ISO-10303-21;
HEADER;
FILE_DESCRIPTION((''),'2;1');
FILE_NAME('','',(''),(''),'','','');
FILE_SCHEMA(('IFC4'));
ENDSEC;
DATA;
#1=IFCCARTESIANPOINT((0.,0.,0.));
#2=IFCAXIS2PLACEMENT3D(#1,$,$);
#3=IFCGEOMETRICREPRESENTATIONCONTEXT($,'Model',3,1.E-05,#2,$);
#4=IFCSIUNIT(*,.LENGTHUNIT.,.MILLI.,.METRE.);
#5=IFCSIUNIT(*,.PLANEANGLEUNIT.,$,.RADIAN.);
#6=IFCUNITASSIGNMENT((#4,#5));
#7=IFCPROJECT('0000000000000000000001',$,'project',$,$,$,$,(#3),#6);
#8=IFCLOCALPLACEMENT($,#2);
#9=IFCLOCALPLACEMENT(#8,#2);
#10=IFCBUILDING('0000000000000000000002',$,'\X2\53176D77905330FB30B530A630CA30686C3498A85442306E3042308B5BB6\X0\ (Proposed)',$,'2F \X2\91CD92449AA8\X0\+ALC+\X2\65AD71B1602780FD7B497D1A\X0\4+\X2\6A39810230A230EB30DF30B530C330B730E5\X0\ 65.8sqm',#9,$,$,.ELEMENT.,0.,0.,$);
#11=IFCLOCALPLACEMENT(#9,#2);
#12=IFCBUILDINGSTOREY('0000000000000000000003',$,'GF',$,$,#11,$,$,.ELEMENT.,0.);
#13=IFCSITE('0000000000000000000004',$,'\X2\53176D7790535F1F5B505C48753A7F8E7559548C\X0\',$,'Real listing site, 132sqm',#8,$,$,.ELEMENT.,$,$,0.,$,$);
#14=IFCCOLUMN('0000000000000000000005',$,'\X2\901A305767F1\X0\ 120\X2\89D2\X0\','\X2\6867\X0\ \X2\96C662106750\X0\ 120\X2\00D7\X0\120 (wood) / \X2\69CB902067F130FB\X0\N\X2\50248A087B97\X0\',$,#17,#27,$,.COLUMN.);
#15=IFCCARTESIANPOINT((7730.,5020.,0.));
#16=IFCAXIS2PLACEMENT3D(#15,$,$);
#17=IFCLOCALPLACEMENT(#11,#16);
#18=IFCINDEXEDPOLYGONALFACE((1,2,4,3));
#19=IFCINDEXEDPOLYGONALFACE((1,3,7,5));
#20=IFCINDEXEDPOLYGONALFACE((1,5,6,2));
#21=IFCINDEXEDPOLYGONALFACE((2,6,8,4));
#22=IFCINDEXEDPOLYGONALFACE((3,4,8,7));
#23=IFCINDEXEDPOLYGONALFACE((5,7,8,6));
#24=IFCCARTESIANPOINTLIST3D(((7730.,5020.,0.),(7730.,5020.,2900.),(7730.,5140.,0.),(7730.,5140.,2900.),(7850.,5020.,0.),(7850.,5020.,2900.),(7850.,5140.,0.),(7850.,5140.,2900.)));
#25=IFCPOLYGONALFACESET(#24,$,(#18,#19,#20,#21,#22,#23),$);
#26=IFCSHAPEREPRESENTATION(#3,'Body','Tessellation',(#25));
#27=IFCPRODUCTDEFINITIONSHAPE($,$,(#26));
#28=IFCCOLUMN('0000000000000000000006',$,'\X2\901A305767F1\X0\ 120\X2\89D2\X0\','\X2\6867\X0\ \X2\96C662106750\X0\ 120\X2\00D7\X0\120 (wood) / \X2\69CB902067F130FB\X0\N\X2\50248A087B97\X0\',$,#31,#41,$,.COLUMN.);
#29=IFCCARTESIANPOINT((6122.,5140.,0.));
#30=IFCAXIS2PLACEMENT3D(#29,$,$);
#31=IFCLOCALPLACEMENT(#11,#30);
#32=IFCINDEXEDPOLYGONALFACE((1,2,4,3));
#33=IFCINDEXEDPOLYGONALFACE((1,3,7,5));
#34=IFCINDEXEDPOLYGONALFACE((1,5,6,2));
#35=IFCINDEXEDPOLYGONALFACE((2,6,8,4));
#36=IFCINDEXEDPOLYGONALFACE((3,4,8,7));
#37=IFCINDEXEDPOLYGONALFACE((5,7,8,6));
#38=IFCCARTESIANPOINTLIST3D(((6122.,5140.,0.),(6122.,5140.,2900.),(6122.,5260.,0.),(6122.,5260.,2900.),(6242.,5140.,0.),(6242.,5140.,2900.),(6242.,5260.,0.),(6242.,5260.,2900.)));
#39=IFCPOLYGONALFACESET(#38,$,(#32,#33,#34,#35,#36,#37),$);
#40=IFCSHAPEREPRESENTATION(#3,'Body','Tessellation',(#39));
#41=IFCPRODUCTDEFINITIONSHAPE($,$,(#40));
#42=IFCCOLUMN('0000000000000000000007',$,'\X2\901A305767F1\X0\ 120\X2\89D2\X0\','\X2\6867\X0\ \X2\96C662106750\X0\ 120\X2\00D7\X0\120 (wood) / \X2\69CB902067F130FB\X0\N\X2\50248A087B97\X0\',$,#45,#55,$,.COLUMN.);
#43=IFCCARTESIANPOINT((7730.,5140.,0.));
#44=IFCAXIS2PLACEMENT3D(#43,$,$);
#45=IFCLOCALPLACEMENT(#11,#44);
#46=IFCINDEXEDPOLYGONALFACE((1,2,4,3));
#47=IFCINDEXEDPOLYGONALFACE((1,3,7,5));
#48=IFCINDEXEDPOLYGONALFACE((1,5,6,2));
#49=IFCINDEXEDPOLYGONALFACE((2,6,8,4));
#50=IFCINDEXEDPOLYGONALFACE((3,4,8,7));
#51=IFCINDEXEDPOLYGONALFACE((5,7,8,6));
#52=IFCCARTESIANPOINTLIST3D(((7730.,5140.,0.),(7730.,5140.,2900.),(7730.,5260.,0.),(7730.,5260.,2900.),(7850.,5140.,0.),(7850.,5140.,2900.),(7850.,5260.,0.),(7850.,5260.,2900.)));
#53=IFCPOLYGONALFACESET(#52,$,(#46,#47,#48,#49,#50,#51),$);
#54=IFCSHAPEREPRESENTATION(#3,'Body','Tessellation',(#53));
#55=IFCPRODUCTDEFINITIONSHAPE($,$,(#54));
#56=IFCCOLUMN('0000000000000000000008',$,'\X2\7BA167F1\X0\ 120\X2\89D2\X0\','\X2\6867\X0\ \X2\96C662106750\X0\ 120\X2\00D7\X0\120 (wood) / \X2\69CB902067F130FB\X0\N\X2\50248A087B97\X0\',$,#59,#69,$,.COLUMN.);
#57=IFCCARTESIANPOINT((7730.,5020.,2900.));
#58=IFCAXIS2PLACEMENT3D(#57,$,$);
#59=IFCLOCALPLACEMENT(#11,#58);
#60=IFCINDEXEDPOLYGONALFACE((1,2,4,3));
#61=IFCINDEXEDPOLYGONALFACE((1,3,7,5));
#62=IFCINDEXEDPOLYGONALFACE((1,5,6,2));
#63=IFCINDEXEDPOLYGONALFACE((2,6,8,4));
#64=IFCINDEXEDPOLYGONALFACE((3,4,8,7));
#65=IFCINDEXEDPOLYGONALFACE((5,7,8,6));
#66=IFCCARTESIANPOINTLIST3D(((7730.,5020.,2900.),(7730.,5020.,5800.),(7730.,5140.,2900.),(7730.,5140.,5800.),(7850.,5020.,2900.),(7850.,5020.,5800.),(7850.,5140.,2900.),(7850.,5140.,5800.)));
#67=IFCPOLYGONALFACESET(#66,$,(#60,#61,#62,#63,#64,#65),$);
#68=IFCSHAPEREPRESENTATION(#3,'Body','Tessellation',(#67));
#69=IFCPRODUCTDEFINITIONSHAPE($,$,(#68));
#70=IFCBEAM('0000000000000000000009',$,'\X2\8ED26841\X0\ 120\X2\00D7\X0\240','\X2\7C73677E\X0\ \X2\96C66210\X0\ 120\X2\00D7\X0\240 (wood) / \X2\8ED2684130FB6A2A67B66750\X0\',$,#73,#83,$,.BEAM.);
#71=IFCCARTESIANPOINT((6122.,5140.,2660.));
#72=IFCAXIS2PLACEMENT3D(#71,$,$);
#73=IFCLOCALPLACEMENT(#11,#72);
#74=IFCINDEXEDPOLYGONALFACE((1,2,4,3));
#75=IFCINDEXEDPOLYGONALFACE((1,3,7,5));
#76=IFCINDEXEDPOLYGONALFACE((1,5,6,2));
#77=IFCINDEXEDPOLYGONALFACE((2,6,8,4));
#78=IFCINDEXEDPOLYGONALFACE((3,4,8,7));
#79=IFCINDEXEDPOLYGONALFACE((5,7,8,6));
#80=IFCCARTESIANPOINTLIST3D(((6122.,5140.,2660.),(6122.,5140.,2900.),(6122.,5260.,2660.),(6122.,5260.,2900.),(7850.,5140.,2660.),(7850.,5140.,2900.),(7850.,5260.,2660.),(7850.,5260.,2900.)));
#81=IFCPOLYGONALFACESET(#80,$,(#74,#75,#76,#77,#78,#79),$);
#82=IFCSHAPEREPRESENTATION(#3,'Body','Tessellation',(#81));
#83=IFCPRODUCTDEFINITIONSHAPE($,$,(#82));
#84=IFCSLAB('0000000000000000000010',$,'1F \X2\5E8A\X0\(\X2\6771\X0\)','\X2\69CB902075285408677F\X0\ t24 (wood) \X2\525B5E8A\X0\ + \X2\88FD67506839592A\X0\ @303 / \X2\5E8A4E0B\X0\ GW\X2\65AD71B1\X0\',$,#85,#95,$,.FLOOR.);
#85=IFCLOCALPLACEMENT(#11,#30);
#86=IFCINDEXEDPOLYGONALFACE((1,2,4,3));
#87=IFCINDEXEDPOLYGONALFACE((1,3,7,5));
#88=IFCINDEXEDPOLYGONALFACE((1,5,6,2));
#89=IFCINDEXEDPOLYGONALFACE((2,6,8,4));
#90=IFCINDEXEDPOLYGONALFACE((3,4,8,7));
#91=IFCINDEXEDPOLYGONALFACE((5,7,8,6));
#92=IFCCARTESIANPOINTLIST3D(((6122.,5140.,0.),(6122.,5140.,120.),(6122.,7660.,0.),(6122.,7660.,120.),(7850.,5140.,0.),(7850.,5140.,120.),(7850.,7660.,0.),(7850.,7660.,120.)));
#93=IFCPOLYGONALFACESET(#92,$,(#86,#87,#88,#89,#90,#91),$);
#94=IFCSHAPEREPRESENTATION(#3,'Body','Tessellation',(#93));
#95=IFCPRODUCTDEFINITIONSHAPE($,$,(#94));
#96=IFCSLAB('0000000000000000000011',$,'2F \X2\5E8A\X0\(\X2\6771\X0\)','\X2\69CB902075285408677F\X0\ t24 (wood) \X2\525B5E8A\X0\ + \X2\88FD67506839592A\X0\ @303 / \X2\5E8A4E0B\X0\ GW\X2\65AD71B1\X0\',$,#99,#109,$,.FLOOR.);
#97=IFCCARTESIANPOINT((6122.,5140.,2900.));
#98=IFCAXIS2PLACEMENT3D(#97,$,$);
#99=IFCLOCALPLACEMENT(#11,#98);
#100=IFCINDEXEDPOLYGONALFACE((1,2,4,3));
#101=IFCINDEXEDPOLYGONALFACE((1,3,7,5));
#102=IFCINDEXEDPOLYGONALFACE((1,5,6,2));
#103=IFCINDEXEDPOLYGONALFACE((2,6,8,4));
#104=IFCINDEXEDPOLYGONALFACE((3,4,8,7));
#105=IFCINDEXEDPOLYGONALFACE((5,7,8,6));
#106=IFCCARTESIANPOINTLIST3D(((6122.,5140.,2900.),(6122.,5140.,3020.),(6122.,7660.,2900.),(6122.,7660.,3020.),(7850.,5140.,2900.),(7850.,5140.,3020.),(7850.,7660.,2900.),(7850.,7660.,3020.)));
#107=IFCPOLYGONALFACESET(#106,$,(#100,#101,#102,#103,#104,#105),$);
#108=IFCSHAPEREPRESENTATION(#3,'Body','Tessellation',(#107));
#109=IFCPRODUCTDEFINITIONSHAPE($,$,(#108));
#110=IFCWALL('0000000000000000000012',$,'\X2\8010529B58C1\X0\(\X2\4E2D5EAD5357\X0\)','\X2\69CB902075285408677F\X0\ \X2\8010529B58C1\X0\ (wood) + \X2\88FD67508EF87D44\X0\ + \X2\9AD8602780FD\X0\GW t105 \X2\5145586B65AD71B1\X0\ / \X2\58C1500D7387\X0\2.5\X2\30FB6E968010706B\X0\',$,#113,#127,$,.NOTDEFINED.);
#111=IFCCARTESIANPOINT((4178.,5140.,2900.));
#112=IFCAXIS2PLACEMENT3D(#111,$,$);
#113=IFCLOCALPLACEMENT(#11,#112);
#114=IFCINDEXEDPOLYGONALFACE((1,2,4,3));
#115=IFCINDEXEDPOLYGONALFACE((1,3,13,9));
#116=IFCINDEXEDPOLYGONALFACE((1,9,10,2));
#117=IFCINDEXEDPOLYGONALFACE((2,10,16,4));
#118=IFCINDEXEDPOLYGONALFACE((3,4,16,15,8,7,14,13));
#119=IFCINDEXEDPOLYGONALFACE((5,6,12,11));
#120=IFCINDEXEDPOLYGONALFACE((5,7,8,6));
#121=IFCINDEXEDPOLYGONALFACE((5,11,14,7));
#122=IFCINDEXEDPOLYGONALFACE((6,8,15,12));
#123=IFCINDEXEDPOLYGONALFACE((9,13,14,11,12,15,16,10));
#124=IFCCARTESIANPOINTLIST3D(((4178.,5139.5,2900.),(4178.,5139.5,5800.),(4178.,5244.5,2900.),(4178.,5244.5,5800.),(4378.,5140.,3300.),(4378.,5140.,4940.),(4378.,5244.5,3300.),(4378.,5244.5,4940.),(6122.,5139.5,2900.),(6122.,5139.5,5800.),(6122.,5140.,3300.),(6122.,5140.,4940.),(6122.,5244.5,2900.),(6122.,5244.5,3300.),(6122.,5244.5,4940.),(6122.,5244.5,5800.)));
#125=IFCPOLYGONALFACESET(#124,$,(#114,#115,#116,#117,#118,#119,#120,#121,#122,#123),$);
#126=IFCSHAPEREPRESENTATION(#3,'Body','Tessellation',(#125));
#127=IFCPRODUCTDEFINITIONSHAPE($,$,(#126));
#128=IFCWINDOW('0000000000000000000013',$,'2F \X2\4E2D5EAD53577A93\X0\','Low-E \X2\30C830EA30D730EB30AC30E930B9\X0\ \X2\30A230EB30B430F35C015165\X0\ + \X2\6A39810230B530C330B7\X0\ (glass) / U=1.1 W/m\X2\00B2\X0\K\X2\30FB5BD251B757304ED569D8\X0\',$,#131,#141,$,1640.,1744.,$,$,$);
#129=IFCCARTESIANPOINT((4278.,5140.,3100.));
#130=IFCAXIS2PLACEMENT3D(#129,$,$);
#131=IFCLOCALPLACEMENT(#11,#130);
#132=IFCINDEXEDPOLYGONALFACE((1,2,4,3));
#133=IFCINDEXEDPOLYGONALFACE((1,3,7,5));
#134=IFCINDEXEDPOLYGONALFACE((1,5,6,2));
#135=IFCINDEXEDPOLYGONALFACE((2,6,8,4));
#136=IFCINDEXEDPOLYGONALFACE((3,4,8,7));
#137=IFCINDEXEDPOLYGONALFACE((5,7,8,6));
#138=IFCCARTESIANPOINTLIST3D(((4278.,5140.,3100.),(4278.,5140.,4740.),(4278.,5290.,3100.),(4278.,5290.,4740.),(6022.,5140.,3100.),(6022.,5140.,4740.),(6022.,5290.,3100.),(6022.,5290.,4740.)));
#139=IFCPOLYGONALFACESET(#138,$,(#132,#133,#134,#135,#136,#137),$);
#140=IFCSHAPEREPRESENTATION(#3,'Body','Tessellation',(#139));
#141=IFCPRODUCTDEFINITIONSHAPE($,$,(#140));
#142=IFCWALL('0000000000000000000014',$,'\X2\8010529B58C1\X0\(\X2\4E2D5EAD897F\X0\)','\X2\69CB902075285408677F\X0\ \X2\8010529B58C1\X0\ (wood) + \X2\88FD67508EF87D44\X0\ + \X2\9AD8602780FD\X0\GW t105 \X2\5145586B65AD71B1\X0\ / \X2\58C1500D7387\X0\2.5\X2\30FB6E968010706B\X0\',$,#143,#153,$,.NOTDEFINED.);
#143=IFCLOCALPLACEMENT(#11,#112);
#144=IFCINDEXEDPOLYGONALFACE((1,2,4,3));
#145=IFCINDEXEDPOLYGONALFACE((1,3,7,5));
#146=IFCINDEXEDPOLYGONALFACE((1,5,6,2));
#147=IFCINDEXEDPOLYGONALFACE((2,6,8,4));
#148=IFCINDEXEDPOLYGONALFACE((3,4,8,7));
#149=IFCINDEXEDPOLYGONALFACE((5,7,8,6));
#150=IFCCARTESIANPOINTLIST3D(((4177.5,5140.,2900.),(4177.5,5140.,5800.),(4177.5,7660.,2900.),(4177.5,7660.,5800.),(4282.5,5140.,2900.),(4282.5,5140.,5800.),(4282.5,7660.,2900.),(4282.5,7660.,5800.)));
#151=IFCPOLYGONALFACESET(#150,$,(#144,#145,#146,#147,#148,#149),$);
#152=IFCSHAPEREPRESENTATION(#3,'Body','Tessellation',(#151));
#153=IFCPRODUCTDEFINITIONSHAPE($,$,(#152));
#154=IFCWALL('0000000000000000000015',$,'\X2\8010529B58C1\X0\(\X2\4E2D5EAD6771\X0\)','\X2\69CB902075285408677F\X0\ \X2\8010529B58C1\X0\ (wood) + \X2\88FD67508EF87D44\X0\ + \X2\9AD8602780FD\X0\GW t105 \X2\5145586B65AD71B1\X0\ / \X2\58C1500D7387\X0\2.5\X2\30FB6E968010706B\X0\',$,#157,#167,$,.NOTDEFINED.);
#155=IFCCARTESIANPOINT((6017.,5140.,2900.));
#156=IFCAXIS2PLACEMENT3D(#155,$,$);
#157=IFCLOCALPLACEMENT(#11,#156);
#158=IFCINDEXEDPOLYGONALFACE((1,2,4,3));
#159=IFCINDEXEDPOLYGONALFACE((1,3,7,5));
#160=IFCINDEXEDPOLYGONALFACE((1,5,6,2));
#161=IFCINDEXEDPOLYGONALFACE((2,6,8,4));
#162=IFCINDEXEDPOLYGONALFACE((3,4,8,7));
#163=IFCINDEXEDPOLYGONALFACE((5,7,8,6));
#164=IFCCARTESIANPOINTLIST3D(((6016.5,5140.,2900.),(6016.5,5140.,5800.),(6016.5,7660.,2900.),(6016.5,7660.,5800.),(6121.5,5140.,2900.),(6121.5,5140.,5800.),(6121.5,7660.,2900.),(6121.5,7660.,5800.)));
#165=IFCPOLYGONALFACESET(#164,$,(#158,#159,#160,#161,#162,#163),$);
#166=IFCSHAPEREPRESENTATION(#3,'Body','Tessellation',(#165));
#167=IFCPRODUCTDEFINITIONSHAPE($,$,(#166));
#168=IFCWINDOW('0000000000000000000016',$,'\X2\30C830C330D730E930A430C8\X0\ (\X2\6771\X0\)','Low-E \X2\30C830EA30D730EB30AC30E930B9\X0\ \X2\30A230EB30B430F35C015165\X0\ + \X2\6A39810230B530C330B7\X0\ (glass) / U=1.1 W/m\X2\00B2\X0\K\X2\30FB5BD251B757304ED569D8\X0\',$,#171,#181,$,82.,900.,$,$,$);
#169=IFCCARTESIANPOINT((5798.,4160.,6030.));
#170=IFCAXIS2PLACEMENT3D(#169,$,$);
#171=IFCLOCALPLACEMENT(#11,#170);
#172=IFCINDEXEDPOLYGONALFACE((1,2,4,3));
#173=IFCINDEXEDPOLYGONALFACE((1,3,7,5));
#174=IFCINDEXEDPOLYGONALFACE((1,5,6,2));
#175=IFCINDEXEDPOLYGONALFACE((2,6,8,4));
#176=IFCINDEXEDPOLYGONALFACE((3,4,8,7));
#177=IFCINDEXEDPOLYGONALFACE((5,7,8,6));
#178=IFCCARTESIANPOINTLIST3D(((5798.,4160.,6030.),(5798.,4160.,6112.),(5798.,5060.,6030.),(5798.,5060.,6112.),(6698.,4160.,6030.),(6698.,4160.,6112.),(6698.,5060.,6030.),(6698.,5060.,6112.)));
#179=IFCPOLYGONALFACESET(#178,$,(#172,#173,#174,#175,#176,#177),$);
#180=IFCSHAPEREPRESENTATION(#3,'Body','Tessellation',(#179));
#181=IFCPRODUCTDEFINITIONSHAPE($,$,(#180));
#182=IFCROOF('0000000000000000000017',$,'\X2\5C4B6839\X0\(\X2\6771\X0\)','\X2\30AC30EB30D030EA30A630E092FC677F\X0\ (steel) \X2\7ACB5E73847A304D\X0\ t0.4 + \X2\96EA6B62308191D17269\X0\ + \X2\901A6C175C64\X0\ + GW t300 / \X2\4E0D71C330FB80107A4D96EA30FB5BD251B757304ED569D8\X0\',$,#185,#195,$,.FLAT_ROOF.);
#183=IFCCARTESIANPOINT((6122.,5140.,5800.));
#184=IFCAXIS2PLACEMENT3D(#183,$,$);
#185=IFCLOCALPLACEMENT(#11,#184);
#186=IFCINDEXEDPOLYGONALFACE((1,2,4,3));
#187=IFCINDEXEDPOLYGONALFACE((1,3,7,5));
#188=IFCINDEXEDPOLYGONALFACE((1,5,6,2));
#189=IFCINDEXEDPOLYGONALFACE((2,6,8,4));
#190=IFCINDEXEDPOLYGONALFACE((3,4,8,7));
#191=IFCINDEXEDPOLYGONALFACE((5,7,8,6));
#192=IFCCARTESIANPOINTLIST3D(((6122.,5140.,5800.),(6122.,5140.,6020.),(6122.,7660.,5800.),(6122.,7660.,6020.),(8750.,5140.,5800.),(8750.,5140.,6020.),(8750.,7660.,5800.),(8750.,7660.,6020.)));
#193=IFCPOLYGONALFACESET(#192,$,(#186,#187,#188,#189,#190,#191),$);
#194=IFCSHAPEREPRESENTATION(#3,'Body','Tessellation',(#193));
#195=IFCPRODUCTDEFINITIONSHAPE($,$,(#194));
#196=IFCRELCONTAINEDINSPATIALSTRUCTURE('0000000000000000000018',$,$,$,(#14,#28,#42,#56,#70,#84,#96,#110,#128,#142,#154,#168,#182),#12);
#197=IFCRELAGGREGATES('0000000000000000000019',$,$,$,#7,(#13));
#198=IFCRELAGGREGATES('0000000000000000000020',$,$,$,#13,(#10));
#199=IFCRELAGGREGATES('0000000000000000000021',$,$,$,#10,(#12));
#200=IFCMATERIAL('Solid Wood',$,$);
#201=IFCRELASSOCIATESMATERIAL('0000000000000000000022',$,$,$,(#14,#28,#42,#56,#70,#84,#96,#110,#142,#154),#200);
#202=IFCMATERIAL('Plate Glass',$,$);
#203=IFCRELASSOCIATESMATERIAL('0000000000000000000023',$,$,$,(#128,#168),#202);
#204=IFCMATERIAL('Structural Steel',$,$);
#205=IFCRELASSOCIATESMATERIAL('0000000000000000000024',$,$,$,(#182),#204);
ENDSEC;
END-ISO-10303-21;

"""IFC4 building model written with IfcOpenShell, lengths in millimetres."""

from ifc_helpers import new_model, si_unit, frame, frame_2d, origin, place, context, project, spatial, rectangle, extrude, material, element, fill, save


model = new_model("IFC4")

# Units and contexts
model_context = context("Model", 3, precision=1e-05, world=origin())
ifc_project = project(units=[si_unit("LENGTHUNIT", "METRE", prefix="MILLI"), si_unit("PLANEANGLEUNIT", "RADIAN")], contexts=[model_context])

# Site, building, storey
site_placement = place(None, origin())
site = spatial("IfcSite", under=ifc_project, at=site_placement, Name="北海道弟子屈町美留和", ObjectType="Real listing site, 132sqm", CompositionType="ELEMENT", RefElevation=0.0)
building_placement = place(site_placement, origin())
building = spatial("IfcBuilding", under=site, at=building_placement, Name="北海道・サウナと水風呂のある家 (Proposed)", ObjectType="2F 重鉄骨+ALC+断熱性能等級4+樹脂アルミサッシュ 65.8sqm", CompositionType="ELEMENT", ElevationOfRefHeight=0.0, ElevationOfTerrain=0.0)
storey_placement = place(building_placement, origin())
storey = spatial("IfcBuildingStorey", under=building, at=storey_placement, Name="GF", CompositionType="ELEMENT", Elevation=0.0)

# Columns
ifc_material_1 = material(Name="Solid Wood")
column_1_placement = place(storey_placement, frame((7730.0, 5020.0, 0.0)))
element("IfcColumn", 1, at=column_1_placement, inside=storey, material=ifc_material_1, Name="通し柱 120角", Description="桧 集成材 120×120 (wood) / 構造柱・N値計算", PredefinedType="COLUMN", context=model_context, shape_type="SweptSolid", body=[
    extrude(rectangle(XDim=120.0, YDim=120.0, at=frame_2d((60.0, 60.0))), frame((7730.0, 5020.0, 0.0)), (0.0, 0.0, 1.0), 2900.0),
])
column_2_placement = place(storey_placement, frame((6122.0, 5140.0, 0.0)))
element("IfcColumn", 2, at=column_2_placement, inside=storey, material=ifc_material_1, Name="通し柱 120角", Description="桧 集成材 120×120 (wood) / 構造柱・N値計算", PredefinedType="COLUMN", context=model_context, shape_type="SweptSolid", body=[
    extrude(rectangle(XDim=120.0, YDim=120.0, at=frame_2d((60.0, 60.0))), frame((6122.0, 5140.0, 0.0)), (0.0, 0.0, 1.0), 2900.0),
])
column_3_placement = place(storey_placement, frame((7730.0, 5140.0, 0.0)))
element("IfcColumn", 3, at=column_3_placement, inside=storey, material=ifc_material_1, Name="通し柱 120角", Description="桧 集成材 120×120 (wood) / 構造柱・N値計算", PredefinedType="COLUMN", context=model_context, shape_type="SweptSolid", body=[
    extrude(rectangle(XDim=120.0, YDim=120.0, at=frame_2d((60.0, 60.0))), frame((7730.0, 5140.0, 0.0)), (0.0, 0.0, 1.0), 2900.0),
])
column_4_placement = place(storey_placement, frame((7730.0, 5020.0, 2900.0)))
element("IfcColumn", 4, at=column_4_placement, inside=storey, material=ifc_material_1, Name="管柱 120角", Description="桧 集成材 120×120 (wood) / 構造柱・N値計算", PredefinedType="COLUMN", context=model_context, shape_type="SweptSolid", body=[
    extrude(rectangle(XDim=120.0, YDim=120.0, at=frame_2d((60.0, 60.0))), frame((7730.0, 5020.0, 2900.0)), (0.0, 0.0, 1.0), 2900.0),
])

# Beam
beam_1_placement = place(storey_placement, frame((6122.0, 5140.0, 2660.0)))
element("IfcBeam", 5, at=beam_1_placement, inside=storey, material=ifc_material_1, Name="軒桁 120×240", Description="米松 集成 120×240 (wood) / 軒桁・横架材", PredefinedType="BEAM", context=model_context, shape_type="SweptSolid", body=[
    extrude(rectangle(XDim=1728.0, YDim=120.0, at=frame_2d((864.0, 60.0))), frame((6122.0, 5140.0, 2660.0)), (0.0, 0.0, 1.0), 240.0),
])

# Slabs
slab_1_placement = place(storey_placement, frame((6122.0, 5140.0, 0.0)))
element("IfcSlab", 6, at=slab_1_placement, inside=storey, material=ifc_material_1, Name="1F 床(東)", Description="構造用合板 t24 (wood) 剛床 + 製材根太 @303 / 床下 GW断熱", PredefinedType="FLOOR", context=model_context, shape_type="SweptSolid", body=[
    extrude(rectangle(XDim=1728.0, YDim=2520.0, at=frame_2d((864.0, 1260.0))), frame((6122.0, 5140.0, 0.0)), (0.0, 0.0, 1.0), 120.0),
])
slab_2_placement = place(storey_placement, frame((6122.0, 5140.0, 2900.0)))
element("IfcSlab", 7, at=slab_2_placement, inside=storey, material=ifc_material_1, Name="2F 床(東)", Description="構造用合板 t24 (wood) 剛床 + 製材根太 @303 / 床下 GW断熱", PredefinedType="FLOOR", context=model_context, shape_type="SweptSolid", body=[
    extrude(rectangle(XDim=1728.0, YDim=2520.0, at=frame_2d((864.0, 1260.0))), frame((6122.0, 5140.0, 2900.0)), (0.0, 0.0, 1.0), 120.0),
])

# Wall, opening, window
wall_1_placement = place(storey_placement, frame((4178.0, 5140.0, 2900.0)))
wall_1 = element("IfcWall", 8, at=wall_1_placement, inside=storey, material=ifc_material_1, Name="耐力壁(中庭南)", Description="構造用合板 耐力壁 (wood) + 製材軸組 + 高性能GW t105 充填断熱 / 壁倍率2.5・準耐火", PredefinedType="NOTDEFINED", context=model_context, shape_type="SweptSolid", body=[
    extrude(rectangle(XDim=1944.0, YDim=105.0, at=frame_2d((972.0, 52.0))), frame((4178.0, 5140.0, 2900.0)), (0.0, 0.0, 1.0), 2900.0),
])
opening_placement = place(storey_placement, frame((4278.0, 5140.0, 3100.0)))
opening = element("IfcOpeningElement", 9, at=opening_placement, cuts=wall_1, PredefinedType="NOTDEFINED", context=model_context, shape_type="SweptSolid", body=[
    extrude(rectangle(XDim=1744.0, YDim=150.0, at=frame_2d((872.0, 75.0))), frame((4278.0, 5140.0, 3100.0)), (0.0, 0.0, 1.0), 1640.0),
])
ifc_material_2 = material(Name="Plate Glass")
window_1_placement = place(storey_placement, frame((4278.0, 5140.0, 3100.0)))
window_1 = element("IfcWindow", 10, at=window_1_placement, inside=storey, material=ifc_material_2, Name="2F 中庭南窓", Description="Low-E トリプルガラス アルゴン封入 + 樹脂サッシ (glass) / U=1.1 W/m²K・寒冷地仕様", OverallHeight=1640.0, OverallWidth=1744.0, context=model_context, shape_type="SweptSolid", body=[
    extrude(rectangle(XDim=1744.0, YDim=150.0, at=frame_2d((872.0, 75.0))), frame((4278.0, 5140.0, 3100.0)), (0.0, 0.0, 1.0), 1640.0),
])
fill(opening, window_1)

# Walls
wall_2_placement = place(storey_placement, frame((4178.0, 5140.0, 2900.0)))
element("IfcWall", 11, at=wall_2_placement, inside=storey, material=ifc_material_1, Name="耐力壁(中庭西)", Description="構造用合板 耐力壁 (wood) + 製材軸組 + 高性能GW t105 充填断熱 / 壁倍率2.5・準耐火", PredefinedType="NOTDEFINED", context=model_context, shape_type="SweptSolid", body=[
    extrude(rectangle(XDim=105.0, YDim=2520.0, at=frame_2d((52.0, 1260.0))), frame((4178.0, 5140.0, 2900.0)), (0.0, 0.0, 1.0), 2900.0),
])
wall_3_placement = place(storey_placement, frame((6017.0, 5140.0, 2900.0)))
element("IfcWall", 12, at=wall_3_placement, inside=storey, material=ifc_material_1, Name="耐力壁(中庭東)", Description="構造用合板 耐力壁 (wood) + 製材軸組 + 高性能GW t105 充填断熱 / 壁倍率2.5・準耐火", PredefinedType="NOTDEFINED", context=model_context, shape_type="SweptSolid", body=[
    extrude(rectangle(XDim=105.0, YDim=2520.0, at=frame_2d((52.0, 1260.0))), frame((6017.0, 5140.0, 2900.0)), (0.0, 0.0, 1.0), 2900.0),
])

# Window
window_2_placement = place(storey_placement, frame((5798.0, 4160.0, 6030.0)))
element("IfcWindow", 13, at=window_2_placement, inside=storey, material=ifc_material_2, Name="トップライト (東)", Description="Low-E トリプルガラス アルゴン封入 + 樹脂サッシ (glass) / U=1.1 W/m²K・寒冷地仕様", OverallHeight=82.0, OverallWidth=900.0, context=model_context, shape_type="SweptSolid", body=[
    extrude(rectangle(XDim=900.0, YDim=900.0, at=frame_2d((450.0, 450.0))), frame((5798.0, 4160.0, 6030.0)), (0.0, 0.0, 1.0), 82.0),
])

# Roof
ifc_material_3 = material(Name="Structural Steel")
for number, where, name in (
    (14, (6122.0, 5140.0, 5800.0), "屋根(東)"),
):
    element("IfcRoof", number, at=place(storey_placement, frame(where)), inside=storey, material=ifc_material_3, Name=name, Description="ガルバリウム鋼板 (steel) 立平葺き t0.4 + 雪止め金物 + 通気層 + GW t300 / 不燃・耐積雪・寒冷地仕様", PredefinedType="FLAT_ROOF", context=model_context, shape_type="SweptSolid", body=[
        extrude(rectangle(XDim=2628.0, YDim=2520.0, at=frame_2d((1314.0, 1260.0))), frame((6122.0, 5140.0, 5800.0)), (0.0, 0.0, 1.0), 220.0),
    ])

save(model, "model.ifc")
